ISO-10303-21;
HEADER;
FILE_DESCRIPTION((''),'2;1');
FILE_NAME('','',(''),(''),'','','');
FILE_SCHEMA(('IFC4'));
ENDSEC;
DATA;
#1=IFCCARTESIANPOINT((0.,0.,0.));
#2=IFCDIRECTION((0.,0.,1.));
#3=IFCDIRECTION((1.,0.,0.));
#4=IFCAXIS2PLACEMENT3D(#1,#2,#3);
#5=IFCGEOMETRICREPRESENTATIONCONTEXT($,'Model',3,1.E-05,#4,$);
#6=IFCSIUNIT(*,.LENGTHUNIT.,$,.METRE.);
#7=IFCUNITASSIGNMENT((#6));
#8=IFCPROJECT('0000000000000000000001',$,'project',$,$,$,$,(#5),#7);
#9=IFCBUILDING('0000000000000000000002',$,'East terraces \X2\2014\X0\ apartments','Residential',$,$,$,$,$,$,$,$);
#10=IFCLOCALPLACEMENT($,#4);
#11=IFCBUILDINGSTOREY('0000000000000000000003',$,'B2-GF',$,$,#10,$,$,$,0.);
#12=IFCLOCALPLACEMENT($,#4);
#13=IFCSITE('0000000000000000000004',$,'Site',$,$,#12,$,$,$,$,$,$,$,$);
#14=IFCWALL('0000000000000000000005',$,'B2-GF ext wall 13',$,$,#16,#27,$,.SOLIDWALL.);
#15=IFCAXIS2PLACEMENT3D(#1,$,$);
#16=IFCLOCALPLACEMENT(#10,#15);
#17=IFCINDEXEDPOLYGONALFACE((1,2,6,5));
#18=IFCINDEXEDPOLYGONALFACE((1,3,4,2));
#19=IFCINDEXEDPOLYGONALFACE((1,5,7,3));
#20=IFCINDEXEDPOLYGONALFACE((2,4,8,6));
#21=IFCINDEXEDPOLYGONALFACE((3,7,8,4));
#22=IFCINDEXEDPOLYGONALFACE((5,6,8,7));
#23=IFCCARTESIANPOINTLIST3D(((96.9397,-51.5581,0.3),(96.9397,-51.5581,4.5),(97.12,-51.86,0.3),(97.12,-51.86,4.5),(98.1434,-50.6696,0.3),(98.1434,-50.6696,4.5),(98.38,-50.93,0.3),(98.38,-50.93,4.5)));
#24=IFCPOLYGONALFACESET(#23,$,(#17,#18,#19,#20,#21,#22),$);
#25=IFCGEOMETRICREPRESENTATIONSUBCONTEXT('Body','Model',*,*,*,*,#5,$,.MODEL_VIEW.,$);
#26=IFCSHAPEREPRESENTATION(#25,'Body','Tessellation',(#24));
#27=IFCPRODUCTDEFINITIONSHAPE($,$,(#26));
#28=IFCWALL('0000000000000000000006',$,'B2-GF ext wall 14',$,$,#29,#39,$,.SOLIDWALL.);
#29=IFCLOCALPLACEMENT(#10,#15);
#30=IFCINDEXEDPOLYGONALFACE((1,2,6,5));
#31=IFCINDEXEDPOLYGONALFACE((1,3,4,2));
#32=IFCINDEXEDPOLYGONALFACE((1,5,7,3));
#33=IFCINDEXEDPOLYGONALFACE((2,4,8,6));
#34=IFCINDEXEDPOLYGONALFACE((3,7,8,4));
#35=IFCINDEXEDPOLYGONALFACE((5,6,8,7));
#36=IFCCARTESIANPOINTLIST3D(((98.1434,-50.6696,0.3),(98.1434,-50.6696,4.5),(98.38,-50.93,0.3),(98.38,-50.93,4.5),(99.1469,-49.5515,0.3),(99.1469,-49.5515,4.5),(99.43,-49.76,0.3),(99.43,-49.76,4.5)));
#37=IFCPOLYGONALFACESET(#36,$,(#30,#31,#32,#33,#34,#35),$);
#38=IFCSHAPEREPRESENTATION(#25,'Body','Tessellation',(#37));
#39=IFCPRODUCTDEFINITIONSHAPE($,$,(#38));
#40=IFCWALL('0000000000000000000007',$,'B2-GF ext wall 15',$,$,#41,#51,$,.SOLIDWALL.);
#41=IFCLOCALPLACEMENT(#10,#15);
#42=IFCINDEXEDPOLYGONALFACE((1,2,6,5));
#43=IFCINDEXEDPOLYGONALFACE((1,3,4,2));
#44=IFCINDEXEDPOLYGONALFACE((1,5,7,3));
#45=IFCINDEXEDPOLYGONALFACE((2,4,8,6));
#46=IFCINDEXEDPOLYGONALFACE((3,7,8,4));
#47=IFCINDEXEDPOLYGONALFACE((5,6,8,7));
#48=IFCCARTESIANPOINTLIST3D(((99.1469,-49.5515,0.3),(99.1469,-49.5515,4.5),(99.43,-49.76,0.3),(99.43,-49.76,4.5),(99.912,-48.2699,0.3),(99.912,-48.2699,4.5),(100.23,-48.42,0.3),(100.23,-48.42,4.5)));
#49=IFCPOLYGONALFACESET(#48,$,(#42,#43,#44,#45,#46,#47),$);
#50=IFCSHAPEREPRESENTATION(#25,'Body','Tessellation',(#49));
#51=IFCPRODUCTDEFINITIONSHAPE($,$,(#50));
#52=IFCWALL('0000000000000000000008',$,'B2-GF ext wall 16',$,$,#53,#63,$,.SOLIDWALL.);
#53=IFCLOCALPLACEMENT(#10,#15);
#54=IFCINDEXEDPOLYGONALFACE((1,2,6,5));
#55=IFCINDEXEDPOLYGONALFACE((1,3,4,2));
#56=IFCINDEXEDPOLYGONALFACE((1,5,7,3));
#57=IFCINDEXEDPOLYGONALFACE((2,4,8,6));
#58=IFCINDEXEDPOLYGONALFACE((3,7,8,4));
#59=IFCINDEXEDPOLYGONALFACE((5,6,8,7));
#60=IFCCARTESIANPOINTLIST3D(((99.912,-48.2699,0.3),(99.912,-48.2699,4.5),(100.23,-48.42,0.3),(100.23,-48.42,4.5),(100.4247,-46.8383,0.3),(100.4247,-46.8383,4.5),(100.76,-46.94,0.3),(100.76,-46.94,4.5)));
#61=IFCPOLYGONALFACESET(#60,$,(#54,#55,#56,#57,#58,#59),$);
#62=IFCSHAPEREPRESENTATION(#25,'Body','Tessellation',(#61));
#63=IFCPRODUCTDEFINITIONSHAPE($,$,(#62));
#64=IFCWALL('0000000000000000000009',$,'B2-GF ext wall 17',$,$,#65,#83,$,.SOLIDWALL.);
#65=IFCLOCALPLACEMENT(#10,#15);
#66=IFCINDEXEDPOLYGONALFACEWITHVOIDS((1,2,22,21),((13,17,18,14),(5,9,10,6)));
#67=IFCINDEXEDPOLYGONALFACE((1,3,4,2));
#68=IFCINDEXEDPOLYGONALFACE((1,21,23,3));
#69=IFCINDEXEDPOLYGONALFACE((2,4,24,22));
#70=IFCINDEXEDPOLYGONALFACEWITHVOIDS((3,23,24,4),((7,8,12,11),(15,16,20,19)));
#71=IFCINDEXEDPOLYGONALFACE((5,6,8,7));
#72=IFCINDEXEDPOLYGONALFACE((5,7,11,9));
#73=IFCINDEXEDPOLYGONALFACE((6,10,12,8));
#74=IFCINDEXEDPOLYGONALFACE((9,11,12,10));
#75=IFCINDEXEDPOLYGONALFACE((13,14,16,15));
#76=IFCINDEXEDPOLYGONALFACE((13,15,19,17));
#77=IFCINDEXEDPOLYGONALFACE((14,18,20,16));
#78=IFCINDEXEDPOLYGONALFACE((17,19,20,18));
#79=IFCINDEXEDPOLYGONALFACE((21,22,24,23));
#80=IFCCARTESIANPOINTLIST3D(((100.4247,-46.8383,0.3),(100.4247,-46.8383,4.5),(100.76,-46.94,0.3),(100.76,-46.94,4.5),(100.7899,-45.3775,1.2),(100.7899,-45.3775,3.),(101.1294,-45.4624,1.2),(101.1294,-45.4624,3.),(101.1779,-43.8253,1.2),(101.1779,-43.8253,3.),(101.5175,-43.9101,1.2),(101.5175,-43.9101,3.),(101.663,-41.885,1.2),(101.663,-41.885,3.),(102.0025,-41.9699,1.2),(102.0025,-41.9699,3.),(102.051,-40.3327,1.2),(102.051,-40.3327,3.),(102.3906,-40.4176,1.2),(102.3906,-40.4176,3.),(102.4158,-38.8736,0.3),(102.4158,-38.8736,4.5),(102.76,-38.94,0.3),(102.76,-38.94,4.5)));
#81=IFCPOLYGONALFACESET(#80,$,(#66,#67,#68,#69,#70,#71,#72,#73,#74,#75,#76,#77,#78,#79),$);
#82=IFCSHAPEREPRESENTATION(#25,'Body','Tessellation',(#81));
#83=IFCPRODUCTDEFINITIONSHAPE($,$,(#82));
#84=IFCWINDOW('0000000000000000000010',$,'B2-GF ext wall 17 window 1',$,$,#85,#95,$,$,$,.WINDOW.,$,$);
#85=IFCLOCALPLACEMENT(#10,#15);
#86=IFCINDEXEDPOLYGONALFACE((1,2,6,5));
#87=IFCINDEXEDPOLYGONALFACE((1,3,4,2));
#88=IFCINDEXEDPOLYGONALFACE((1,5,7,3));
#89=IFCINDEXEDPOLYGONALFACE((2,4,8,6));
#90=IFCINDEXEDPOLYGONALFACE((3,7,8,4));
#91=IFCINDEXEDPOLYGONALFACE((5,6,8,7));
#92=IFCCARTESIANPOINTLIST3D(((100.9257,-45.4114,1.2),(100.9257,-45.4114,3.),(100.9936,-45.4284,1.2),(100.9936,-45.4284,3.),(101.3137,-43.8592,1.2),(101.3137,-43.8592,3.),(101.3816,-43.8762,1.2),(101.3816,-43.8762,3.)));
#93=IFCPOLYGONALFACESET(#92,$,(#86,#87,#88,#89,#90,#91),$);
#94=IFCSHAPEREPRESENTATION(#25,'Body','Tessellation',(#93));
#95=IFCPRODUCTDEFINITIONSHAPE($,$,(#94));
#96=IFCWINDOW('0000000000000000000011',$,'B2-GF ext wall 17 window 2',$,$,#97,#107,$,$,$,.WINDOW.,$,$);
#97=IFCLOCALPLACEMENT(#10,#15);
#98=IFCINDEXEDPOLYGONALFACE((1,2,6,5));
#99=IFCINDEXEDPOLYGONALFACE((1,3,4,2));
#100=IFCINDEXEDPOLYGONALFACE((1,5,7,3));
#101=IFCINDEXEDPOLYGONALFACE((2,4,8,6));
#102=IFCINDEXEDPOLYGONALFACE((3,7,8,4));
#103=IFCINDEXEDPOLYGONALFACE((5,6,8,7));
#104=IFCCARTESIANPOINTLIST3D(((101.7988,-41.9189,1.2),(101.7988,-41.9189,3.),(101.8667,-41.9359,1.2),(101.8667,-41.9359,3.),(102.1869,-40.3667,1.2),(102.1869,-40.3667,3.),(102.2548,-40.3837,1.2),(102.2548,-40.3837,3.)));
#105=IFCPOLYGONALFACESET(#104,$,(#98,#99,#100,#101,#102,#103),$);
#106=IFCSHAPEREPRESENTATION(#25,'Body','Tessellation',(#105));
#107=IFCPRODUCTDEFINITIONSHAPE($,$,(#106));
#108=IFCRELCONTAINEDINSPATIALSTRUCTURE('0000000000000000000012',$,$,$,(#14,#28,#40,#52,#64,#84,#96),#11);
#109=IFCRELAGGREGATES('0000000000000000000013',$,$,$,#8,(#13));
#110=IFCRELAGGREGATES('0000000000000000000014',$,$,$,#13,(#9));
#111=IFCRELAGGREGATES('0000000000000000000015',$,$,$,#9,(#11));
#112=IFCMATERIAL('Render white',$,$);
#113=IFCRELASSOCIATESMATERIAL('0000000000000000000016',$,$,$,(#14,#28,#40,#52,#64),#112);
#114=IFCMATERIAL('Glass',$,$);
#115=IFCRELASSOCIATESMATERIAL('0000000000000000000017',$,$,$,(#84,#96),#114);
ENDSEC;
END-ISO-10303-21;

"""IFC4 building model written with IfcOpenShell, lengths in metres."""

from ifc_helpers import new_model, si_unit, frame, origin_with_axes, place, context, subcontext, project, spatial, polyline, outline, extrude, material, element, fill, save


model = new_model("IFC4")

# Units and contexts
model_context = context("Model", 3, precision=1e-05, world=origin_with_axes())
body_context = subcontext(model_context, "Body", "Model", "MODEL_VIEW")
ifc_project = project(units=[si_unit("LENGTHUNIT", "METRE")], contexts=[model_context])

# Site, building, storey
site_placement = place(None, origin_with_axes())
site = spatial("IfcSite", under=ifc_project, at=site_placement, Name="Site")
building = spatial("IfcBuilding", under=site, Name="East terraces — apartments", Description="Residential")
storey_placement = place(None, origin_with_axes())
storey = spatial("IfcBuildingStorey", under=building, at=storey_placement, Name="B2-GF", Elevation=0.0)

# Shared definitions
ifc_material_1 = material(Name="Render white")
ifc_material_2 = material(Name="Glass")

# Walls
wall_1_placement = place(storey_placement, origin_with_axes())
element("IfcWall", 1, at=wall_1_placement, inside=storey, material=ifc_material_1, Name="B2-GF ext wall 13", PredefinedType="SOLIDWALL", context=body_context, shape_type="SweptSolid", body=[
    extrude(outline(polyline([(97.12, -51.86), (98.38, -50.93), (98.1434, -50.6696), (96.9397, -51.5581), (97.12, -51.86)])), frame((0.0, 0.0, 0.3), z_axis=(0.0, 0.0, 1.0), x_axis=(1.0, 0.0, 0.0)), (0.0, 0.0, 1.0), 4.2),
])
wall_2_placement = place(storey_placement, origin_with_axes())
element("IfcWall", 2, at=wall_2_placement, inside=storey, material=ifc_material_1, Name="B2-GF ext wall 14", PredefinedType="SOLIDWALL", context=body_context, shape_type="SweptSolid", body=[
    extrude(outline(polyline([(98.38, -50.93), (99.43, -49.76), (99.1469, -49.5515), (98.1434, -50.6696), (98.38, -50.93)])), frame((0.0, 0.0, 0.3), z_axis=(0.0, 0.0, 1.0), x_axis=(1.0, 0.0, 0.0)), (0.0, 0.0, 1.0), 4.2),
])
wall_3_placement = place(storey_placement, origin_with_axes())
element("IfcWall", 3, at=wall_3_placement, inside=storey, material=ifc_material_1, Name="B2-GF ext wall 15", PredefinedType="SOLIDWALL", context=body_context, shape_type="SweptSolid", body=[
    extrude(outline(polyline([(99.43, -49.76), (100.23, -48.42), (99.912, -48.2699), (99.1469, -49.5515), (99.43, -49.76)])), frame((0.0, 0.0, 0.3), z_axis=(0.0, 0.0, 1.0), x_axis=(1.0, 0.0, 0.0)), (0.0, 0.0, 1.0), 4.2),
])
wall_4_placement = place(storey_placement, origin_with_axes())
element("IfcWall", 4, at=wall_4_placement, inside=storey, material=ifc_material_1, Name="B2-GF ext wall 16", PredefinedType="SOLIDWALL", context=body_context, shape_type="SweptSolid", body=[
    extrude(outline(polyline([(100.23, -48.42), (100.76, -46.94), (100.4247, -46.8383), (99.912, -48.2699), (100.23, -48.42)])), frame((0.0, 0.0, 0.3), z_axis=(0.0, 0.0, 1.0), x_axis=(1.0, 0.0, 0.0)), (0.0, 0.0, 1.0), 4.2),
])

# Wall, openings, windows
wall_5_placement = place(storey_placement, origin_with_axes())
wall_5 = element("IfcWall", 5, at=wall_5_placement, inside=storey, material=ifc_material_1, Name="B2-GF ext wall 17", PredefinedType="SOLIDWALL", context=body_context, shape_type="SweptSolid", body=[
    extrude(outline(polyline([(100.76, -46.94), (102.76, -38.94), (102.4158, -38.8736), (100.4247, -46.8383), (100.76, -46.94)])), frame((0.0, 0.0, 0.3), z_axis=(0.0, 0.0, 1.0), x_axis=(1.0, 0.0, 0.0)), (0.0, 0.0, 1.0), 4.2),
])
opening_1_placement = place(wall_5_placement, origin_with_axes())
opening_1 = element("IfcOpeningElement", 6, at=opening_1_placement, cuts=wall_5, context=body_context, shape_type="SweptSolid", body=[
    extrude(outline(polyline([(101.1779, -45.4745), (101.566, -43.9223), (101.1294, -43.8131), (100.7414, -45.3654), (101.1779, -45.4745)])), frame((0.0, 0.0, 1.2), z_axis=(0.0, 0.0, 1.0), x_axis=(1.0, 0.0, 0.0)), (0.0, 0.0, 1.0), 1.8),
])
opening_2_placement = place(wall_5_placement, origin_with_axes())
opening_2 = element("IfcOpeningElement", 7, at=opening_2_placement, cuts=wall_5, context=body_context, shape_type="SweptSolid", body=[
    extrude(outline(polyline([(102.051, -41.982), (102.4391, -40.4298), (102.0025, -40.3206), (101.6145, -41.8728), (102.051, -41.982)])), frame((0.0, 0.0, 1.2), z_axis=(0.0, 0.0, 1.0), x_axis=(1.0, 0.0, 0.0)), (0.0, 0.0, 1.0), 1.8),
])
window_1_placement = place(storey_placement, origin_with_axes())
window_1 = element("IfcWindow", 8, at=window_1_placement, inside=storey, material=ifc_material_2, Name="B2-GF ext wall 17 window 1", PredefinedType="WINDOW", context=body_context, shape_type="SweptSolid", body=[
    extrude(outline(polyline([(100.9936, -45.4284), (101.3816, -43.8762), (101.3137, -43.8592), (100.9257, -45.4114), (100.9936, -45.4284)])), frame((0.0, 0.0, 1.2), z_axis=(0.0, 0.0, 1.0), x_axis=(1.0, 0.0, 0.0)), (0.0, 0.0, 1.0), 1.8),
])
fill(opening_1, window_1)
window_2_placement = place(storey_placement, origin_with_axes())
window_2 = element("IfcWindow", 9, at=window_2_placement, inside=storey, material=ifc_material_2, Name="B2-GF ext wall 17 window 2", PredefinedType="WINDOW", context=body_context, shape_type="SweptSolid", body=[
    extrude(outline(polyline([(101.8667, -41.9359), (102.2548, -40.3837), (102.1869, -40.3667), (101.7988, -41.9189), (101.8667, -41.9359)])), frame((0.0, 0.0, 1.2), z_axis=(0.0, 0.0, 1.0), x_axis=(1.0, 0.0, 0.0)), (0.0, 0.0, 1.0), 1.8),
])
fill(opening_2, window_2)

save(model, "model.ifc")
